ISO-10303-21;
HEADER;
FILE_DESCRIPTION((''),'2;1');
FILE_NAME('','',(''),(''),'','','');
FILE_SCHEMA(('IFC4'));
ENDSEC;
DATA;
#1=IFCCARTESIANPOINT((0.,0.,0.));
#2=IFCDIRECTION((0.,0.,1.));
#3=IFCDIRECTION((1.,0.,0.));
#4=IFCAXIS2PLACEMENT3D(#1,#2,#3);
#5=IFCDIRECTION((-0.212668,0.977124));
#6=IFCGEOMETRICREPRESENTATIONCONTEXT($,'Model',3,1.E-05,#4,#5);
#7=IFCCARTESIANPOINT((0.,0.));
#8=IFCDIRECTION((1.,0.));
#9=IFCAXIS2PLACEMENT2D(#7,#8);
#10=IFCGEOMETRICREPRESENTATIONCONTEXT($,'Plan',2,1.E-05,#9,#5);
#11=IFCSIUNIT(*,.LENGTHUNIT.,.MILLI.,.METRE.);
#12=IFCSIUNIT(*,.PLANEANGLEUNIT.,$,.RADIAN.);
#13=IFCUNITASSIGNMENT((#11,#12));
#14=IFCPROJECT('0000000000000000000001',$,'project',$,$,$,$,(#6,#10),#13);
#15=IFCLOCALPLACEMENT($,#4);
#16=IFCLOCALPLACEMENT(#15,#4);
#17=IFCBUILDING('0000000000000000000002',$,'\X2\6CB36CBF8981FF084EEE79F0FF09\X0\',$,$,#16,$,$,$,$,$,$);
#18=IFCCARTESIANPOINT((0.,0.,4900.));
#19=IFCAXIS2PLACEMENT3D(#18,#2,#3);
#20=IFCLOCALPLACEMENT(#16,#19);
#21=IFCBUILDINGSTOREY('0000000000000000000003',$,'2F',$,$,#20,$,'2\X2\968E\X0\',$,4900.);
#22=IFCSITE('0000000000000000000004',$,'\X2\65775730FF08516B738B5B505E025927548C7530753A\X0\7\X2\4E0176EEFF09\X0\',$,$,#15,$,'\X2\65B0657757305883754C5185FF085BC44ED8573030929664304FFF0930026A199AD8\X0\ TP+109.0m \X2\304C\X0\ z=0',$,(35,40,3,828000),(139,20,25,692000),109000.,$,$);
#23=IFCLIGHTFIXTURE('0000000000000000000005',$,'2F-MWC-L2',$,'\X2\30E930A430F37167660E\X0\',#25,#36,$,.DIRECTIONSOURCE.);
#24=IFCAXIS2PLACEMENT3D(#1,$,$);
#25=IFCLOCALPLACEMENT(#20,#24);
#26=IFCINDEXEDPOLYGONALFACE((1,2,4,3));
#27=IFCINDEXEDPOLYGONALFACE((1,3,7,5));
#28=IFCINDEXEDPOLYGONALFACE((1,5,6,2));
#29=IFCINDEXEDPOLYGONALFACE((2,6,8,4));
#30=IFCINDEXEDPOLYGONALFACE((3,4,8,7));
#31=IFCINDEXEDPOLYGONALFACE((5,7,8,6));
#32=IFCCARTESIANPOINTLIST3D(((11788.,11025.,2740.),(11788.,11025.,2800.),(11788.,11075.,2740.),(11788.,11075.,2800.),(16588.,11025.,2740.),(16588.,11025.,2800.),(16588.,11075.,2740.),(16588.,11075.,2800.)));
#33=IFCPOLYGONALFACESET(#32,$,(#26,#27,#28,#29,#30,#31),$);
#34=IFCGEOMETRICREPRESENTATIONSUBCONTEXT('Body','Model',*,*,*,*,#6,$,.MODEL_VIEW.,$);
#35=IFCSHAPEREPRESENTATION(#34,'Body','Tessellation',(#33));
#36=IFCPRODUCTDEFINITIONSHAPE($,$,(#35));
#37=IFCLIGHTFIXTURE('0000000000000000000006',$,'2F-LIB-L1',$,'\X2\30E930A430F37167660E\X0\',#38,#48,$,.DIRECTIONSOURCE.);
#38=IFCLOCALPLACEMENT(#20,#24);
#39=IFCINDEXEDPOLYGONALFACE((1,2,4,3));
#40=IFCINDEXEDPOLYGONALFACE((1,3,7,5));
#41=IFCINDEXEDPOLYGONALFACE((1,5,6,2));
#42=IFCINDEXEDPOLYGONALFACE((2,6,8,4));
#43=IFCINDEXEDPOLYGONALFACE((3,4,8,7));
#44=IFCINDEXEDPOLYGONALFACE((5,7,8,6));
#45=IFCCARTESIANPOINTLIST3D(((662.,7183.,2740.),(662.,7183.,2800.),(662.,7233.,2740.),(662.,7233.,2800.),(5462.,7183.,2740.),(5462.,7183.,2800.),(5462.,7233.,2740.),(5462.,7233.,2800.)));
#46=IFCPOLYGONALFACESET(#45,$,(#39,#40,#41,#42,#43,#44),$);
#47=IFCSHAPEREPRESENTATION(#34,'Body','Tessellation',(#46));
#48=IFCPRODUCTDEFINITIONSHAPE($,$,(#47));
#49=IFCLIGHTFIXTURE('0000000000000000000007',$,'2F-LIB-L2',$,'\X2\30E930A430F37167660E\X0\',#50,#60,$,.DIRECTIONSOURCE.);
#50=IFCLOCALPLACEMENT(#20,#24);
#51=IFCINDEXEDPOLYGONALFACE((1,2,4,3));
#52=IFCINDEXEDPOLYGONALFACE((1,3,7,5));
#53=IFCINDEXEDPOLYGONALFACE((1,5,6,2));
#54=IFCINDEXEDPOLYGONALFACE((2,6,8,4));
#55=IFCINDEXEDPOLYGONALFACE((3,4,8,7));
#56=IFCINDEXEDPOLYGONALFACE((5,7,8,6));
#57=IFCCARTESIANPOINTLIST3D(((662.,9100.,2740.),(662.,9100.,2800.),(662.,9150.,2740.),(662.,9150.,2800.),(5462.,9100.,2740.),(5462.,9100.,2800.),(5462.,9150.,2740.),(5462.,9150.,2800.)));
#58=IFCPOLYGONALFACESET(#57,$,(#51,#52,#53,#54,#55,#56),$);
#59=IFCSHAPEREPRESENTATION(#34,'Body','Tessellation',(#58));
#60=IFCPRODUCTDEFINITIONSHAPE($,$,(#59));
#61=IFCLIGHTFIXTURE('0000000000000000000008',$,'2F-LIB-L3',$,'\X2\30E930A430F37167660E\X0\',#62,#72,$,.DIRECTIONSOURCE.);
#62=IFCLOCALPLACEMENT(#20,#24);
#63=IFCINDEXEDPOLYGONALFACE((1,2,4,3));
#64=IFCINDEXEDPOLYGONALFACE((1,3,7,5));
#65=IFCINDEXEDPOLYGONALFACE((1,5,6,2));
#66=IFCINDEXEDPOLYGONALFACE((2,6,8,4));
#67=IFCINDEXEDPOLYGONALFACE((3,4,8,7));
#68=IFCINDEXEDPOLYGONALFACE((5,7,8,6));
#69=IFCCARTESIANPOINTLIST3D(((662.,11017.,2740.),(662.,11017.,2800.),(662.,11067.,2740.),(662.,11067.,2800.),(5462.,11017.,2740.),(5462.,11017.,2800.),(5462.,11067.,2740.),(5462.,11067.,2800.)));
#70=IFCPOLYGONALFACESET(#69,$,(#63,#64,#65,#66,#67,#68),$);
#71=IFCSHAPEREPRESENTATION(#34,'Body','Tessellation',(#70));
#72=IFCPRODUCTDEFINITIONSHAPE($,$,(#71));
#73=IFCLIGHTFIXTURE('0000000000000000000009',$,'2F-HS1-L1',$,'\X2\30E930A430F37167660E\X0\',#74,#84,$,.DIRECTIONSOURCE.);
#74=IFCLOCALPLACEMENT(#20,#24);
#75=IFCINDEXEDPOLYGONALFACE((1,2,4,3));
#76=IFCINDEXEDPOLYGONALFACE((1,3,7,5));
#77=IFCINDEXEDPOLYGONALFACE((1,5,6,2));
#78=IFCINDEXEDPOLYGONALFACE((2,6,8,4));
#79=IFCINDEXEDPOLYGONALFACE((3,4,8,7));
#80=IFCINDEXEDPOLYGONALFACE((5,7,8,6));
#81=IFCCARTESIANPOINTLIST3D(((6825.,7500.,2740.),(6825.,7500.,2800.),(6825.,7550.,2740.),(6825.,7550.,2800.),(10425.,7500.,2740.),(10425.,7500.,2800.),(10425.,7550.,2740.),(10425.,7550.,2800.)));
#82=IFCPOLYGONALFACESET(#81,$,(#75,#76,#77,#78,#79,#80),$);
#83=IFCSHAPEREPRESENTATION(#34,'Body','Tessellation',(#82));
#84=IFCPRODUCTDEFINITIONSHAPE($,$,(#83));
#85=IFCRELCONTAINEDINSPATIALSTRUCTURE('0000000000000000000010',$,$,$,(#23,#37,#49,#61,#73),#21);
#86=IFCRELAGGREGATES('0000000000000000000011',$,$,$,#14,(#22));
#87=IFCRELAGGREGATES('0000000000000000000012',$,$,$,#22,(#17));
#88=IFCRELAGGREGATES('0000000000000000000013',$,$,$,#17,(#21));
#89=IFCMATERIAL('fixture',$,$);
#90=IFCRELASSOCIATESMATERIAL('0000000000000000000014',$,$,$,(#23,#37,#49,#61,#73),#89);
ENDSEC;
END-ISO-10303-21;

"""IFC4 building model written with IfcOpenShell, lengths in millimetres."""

from ifc_helpers import new_model, si_unit, direction, frame, frame_2d, origin_with_axes, origin_2d_with_axis, place, context, subcontext, project, spatial, rectangle, extrude, material, element, save


model = new_model("IFC4")

# Units and contexts
model_context = context("Model", 3, precision=1e-05, world=origin_with_axes(), true_north=direction((-0.212668, 0.977124)))
plan_context = context("Plan", 2, precision=1e-05, world=origin_2d_with_axis(), true_north=direction((-0.212668, 0.977124)))
body_context = subcontext(model_context, "Body", "Model", "MODEL_VIEW")
ifc_project = project(units=[si_unit("LENGTHUNIT", "METRE", prefix="MILLI"), si_unit("PLANEANGLEUNIT", "RADIAN")], contexts=[model_context, plan_context])

# Site, building, storey
site_placement = place(None, origin_with_axes())
site = spatial("IfcSite", under=ifc_project, at=site_placement, Name="敷地（八王子市大和田町7丁目）", LongName="新敷地境界内（寄付地を除く）。標高 TP+109.0m が z=0", RefLatitude=(35, 40, 3, 828000), RefLongitude=(139, 20, 25, 692000), RefElevation=109000.0)
building_placement = place(site_placement, origin_with_axes())
building = spatial("IfcBuilding", under=site, at=building_placement, Name="河沿要（仮称）")
storey_placement = place(building_placement, frame((0.0, 0.0, 4900.0), z_axis=(0.0, 0.0, 1.0), x_axis=(1.0, 0.0, 0.0)))
storey = spatial("IfcBuildingStorey", under=building, at=storey_placement, Name="2F", LongName="2階", Elevation=4900.0)

# Light fixtures
ifc_material_1 = material(Name="fixture")
light_fixture_1_placement = place(storey_placement, origin_with_axes())
element("IfcLightFixture", 1, at=light_fixture_1_placement, inside=storey, material=ifc_material_1, Name="2F-MWC-L2", ObjectType="ライン照明", PredefinedType="DIRECTIONSOURCE", context=body_context, shape_type="SweptSolid", body=[
    extrude(rectangle(XDim=4800.0, YDim=50.0, at=frame_2d((14188.0, 11050.0))), frame((0.0, 0.0, 2740.0)), (0.0, 0.0, 1.0), 60.0),
])
light_fixture_2_placement = place(storey_placement, origin_with_axes())
element("IfcLightFixture", 2, at=light_fixture_2_placement, inside=storey, material=ifc_material_1, Name="2F-LIB-L1", ObjectType="ライン照明", PredefinedType="DIRECTIONSOURCE", context=body_context, shape_type="SweptSolid", body=[
    extrude(rectangle(XDim=4800.0, YDim=50.0, at=frame_2d((3062.0, 7208.0))), frame((0.0, 0.0, 2740.0)), (0.0, 0.0, 1.0), 60.0),
])
light_fixture_3_placement = place(storey_placement, origin_with_axes())
element("IfcLightFixture", 3, at=light_fixture_3_placement, inside=storey, material=ifc_material_1, Name="2F-LIB-L2", ObjectType="ライン照明", PredefinedType="DIRECTIONSOURCE", context=body_context, shape_type="SweptSolid", body=[
    extrude(rectangle(XDim=4800.0, YDim=50.0, at=frame_2d((3062.0, 9125.0))), frame((0.0, 0.0, 2740.0)), (0.0, 0.0, 1.0), 60.0),
])
light_fixture_4_placement = place(storey_placement, origin_with_axes())
element("IfcLightFixture", 4, at=light_fixture_4_placement, inside=storey, material=ifc_material_1, Name="2F-LIB-L3", ObjectType="ライン照明", PredefinedType="DIRECTIONSOURCE", context=body_context, shape_type="SweptSolid", body=[
    extrude(rectangle(XDim=4800.0, YDim=50.0, at=frame_2d((3062.0, 11042.0))), frame((0.0, 0.0, 2740.0)), (0.0, 0.0, 1.0), 60.0),
])
light_fixture_5_placement = place(storey_placement, origin_with_axes())
element("IfcLightFixture", 5, at=light_fixture_5_placement, inside=storey, material=ifc_material_1, Name="2F-HS1-L1", ObjectType="ライン照明", PredefinedType="DIRECTIONSOURCE", context=body_context, shape_type="SweptSolid", body=[
    extrude(rectangle(XDim=3600.0, YDim=50.0, at=frame_2d((8625.0, 7525.0))), frame((0.0, 0.0, 2740.0)), (0.0, 0.0, 1.0), 60.0),
])

save(model, "model.ifc")
